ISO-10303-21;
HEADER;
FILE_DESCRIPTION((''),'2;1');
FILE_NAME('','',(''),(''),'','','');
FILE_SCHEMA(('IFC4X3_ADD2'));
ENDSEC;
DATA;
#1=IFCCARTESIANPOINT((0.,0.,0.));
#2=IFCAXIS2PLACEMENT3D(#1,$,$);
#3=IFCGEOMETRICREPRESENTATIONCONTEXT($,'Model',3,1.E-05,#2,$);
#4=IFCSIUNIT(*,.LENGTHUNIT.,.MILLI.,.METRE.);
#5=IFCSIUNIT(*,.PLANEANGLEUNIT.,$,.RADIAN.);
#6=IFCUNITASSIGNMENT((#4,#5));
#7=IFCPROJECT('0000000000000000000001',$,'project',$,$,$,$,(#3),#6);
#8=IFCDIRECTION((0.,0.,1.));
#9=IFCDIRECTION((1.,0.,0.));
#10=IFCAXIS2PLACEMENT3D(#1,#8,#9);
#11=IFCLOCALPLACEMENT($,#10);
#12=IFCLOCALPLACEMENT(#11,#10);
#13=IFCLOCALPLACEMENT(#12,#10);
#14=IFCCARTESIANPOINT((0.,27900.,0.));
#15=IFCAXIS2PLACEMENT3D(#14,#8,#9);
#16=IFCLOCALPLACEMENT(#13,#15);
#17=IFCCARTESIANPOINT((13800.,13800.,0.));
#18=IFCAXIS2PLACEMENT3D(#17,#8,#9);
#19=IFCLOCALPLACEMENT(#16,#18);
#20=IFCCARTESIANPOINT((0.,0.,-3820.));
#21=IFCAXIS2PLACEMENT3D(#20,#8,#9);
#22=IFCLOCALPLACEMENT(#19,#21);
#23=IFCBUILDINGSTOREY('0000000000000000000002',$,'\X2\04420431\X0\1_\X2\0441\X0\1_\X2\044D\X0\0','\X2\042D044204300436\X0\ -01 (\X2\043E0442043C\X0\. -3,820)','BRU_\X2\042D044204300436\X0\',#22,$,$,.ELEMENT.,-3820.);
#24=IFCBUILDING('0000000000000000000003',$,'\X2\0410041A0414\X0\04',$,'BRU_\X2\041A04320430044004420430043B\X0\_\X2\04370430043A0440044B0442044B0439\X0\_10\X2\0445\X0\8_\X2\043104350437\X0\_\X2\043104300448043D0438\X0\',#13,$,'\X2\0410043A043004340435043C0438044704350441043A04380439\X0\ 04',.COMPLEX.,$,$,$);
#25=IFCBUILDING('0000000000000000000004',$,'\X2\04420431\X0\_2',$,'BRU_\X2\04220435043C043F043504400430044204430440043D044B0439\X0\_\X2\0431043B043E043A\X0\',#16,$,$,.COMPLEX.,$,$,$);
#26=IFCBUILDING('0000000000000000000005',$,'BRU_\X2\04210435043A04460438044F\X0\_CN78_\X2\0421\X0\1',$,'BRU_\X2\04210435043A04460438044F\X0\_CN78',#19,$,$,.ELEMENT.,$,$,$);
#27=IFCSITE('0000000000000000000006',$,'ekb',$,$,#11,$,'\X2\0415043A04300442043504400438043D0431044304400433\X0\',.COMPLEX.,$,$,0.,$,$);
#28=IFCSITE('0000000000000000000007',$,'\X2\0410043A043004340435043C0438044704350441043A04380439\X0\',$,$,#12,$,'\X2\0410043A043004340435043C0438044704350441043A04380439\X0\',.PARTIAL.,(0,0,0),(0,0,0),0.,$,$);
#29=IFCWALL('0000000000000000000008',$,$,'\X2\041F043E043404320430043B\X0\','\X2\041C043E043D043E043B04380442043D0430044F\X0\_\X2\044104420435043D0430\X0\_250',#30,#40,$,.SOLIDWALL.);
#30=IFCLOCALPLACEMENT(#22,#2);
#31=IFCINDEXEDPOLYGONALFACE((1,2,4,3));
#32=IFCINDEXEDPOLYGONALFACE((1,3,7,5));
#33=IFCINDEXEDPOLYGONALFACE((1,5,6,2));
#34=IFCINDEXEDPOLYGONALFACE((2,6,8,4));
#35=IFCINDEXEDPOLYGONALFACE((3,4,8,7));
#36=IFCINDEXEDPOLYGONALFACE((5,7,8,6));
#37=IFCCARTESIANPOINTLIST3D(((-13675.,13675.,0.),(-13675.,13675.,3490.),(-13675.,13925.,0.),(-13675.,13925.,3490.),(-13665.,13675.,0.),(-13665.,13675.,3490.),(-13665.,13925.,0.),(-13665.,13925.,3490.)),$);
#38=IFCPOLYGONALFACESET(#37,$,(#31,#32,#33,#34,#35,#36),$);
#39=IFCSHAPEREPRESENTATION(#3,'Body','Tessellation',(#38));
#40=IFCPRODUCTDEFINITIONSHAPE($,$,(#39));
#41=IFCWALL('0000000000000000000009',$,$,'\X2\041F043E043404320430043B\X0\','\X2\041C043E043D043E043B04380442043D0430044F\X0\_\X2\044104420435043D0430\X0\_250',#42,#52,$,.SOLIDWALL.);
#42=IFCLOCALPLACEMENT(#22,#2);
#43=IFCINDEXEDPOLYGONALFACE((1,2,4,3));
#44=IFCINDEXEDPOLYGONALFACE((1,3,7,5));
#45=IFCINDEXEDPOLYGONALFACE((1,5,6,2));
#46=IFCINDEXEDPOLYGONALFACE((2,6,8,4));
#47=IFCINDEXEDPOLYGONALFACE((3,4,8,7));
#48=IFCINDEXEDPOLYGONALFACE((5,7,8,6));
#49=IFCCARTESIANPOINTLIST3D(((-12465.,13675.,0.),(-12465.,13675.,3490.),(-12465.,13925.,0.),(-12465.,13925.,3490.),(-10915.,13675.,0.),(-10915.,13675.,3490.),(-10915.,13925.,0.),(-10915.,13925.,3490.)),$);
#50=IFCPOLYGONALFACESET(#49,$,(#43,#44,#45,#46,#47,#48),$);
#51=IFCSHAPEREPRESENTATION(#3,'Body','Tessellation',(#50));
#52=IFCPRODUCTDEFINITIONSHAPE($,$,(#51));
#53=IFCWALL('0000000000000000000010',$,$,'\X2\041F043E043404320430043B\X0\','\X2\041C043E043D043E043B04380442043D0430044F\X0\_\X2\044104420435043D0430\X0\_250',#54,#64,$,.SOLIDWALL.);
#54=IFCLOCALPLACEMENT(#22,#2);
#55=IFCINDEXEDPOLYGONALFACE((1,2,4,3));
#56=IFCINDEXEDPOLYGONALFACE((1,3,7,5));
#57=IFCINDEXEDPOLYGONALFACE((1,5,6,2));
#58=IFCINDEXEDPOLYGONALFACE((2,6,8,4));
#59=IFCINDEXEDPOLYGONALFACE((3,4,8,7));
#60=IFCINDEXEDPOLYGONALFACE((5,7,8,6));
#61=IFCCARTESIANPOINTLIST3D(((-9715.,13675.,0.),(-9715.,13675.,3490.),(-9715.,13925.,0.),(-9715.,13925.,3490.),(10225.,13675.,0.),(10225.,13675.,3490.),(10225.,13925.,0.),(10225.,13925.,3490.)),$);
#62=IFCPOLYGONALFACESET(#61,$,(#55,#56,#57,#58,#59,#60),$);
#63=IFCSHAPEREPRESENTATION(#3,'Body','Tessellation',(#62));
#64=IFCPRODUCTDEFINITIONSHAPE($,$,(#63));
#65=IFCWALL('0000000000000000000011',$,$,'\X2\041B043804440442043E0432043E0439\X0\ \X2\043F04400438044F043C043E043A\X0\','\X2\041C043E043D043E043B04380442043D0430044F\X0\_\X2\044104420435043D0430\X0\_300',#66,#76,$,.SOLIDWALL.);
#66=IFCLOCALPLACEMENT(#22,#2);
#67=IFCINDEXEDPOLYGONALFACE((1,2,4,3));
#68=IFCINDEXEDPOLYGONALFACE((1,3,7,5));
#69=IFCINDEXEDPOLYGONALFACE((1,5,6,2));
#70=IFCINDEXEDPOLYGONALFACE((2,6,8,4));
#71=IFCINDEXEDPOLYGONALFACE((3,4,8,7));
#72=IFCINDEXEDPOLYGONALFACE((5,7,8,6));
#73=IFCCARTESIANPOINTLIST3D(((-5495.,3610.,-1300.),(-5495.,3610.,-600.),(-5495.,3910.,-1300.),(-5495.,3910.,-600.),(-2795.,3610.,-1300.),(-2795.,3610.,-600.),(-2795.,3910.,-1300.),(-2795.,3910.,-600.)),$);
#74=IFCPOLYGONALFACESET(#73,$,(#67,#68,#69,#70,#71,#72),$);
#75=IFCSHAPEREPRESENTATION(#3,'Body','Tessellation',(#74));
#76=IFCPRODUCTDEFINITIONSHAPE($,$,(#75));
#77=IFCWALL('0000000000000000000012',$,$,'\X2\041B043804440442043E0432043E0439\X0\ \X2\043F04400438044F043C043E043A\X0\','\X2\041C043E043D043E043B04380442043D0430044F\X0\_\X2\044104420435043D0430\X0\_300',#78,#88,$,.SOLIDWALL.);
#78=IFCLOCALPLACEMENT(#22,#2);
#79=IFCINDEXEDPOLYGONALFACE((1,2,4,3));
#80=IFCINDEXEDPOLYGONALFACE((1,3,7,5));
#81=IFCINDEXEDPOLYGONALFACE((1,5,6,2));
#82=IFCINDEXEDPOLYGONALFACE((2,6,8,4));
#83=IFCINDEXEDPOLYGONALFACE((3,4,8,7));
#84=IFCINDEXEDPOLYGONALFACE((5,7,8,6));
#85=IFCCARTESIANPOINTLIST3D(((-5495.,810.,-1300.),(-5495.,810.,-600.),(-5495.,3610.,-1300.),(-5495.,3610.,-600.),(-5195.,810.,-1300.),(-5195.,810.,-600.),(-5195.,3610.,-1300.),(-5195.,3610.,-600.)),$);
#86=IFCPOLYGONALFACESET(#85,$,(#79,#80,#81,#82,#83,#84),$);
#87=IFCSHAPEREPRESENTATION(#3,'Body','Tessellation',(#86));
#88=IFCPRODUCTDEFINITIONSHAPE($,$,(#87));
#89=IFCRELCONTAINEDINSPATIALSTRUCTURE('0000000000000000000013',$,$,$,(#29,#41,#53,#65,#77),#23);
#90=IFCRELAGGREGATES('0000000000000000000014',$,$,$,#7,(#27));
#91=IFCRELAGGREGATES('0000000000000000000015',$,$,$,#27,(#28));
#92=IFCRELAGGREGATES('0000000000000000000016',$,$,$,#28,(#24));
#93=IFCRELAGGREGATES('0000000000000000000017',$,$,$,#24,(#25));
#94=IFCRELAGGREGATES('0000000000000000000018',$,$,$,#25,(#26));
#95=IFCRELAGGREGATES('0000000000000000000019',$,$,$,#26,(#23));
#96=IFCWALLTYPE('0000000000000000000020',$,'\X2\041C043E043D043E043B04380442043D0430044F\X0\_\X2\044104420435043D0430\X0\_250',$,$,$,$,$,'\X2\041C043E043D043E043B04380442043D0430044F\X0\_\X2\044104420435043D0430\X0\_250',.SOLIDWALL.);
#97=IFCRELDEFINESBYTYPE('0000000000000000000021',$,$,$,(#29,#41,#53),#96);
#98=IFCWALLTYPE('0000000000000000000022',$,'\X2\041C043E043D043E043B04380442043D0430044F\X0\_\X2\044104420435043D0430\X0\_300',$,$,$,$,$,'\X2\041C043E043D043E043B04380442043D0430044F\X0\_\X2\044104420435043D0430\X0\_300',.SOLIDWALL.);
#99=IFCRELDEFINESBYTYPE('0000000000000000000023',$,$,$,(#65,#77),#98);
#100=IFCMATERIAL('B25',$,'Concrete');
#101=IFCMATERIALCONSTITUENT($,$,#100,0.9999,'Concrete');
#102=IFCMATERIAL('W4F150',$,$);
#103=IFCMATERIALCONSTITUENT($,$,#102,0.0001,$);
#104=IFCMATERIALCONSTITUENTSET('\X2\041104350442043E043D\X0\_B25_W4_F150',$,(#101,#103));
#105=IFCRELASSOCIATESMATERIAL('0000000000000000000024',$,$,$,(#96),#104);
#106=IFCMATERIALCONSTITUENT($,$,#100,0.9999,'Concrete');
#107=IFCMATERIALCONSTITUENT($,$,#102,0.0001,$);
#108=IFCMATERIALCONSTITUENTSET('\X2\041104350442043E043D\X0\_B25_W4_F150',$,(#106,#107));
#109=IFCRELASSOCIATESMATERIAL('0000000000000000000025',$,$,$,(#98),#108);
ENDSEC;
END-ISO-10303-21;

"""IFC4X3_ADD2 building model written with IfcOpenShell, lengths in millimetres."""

from ifc_helpers import new_model, si_unit, frame, origin, origin_with_axes, origin_2d_with_axis, place, context, project, spatial, rectangle, extrude, material, constituent, constituent_set, type_object, element, save


model = new_model("IFC4X3_ADD2")

# Units and contexts
model_context = context("Model", 3, precision=1e-05, world=origin())
ifc_project = project(units=[si_unit("LENGTHUNIT", "METRE", prefix="MILLI"), si_unit("PLANEANGLEUNIT", "RADIAN")], contexts=[model_context])

# Sites, buildings, storey
site_1_placement = place(None, origin_with_axes())
site_1 = spatial("IfcSite", under=ifc_project, at=site_1_placement, Name="ekb", LongName="Екатеринбург", CompositionType="COMPLEX", RefElevation=0.0)
site_2_placement = place(site_1_placement, origin_with_axes())
site_2 = spatial("IfcSite", under=site_1, at=site_2_placement, Name="Академический", LongName="Академический", CompositionType="PARTIAL", RefLatitude=(0, 0, 0), RefLongitude=(0, 0, 0), RefElevation=0.0)
building_1_placement = place(site_2_placement, origin_with_axes())
building_1 = spatial("IfcBuilding", under=site_2, at=building_1_placement, Name="АКД04", ObjectType="BRU_Квартал_закрытый_10х8_без_башни", LongName="Академический 04", CompositionType="COMPLEX")
building_2_placement = place(building_1_placement, frame((0.0, 27900.0, 0.0), z_axis=(0.0, 0.0, 1.0), x_axis=(1.0, 0.0, 0.0)))
building_2 = spatial("IfcBuilding", under=building_1, at=building_2_placement, Name="тб_2", ObjectType="BRU_Температурный_блок", CompositionType="COMPLEX")
building_3_placement = place(building_2_placement, frame((13800.0, 13800.0, 0.0), z_axis=(0.0, 0.0, 1.0), x_axis=(1.0, 0.0, 0.0)))
building_3 = spatial("IfcBuilding", under=building_2, at=building_3_placement, Name="BRU_Секция_CN78_С1", ObjectType="BRU_Секция_CN78", CompositionType="ELEMENT")
storey_placement = place(building_3_placement, frame((0.0, 0.0, -3820.0), z_axis=(0.0, 0.0, 1.0), x_axis=(1.0, 0.0, 0.0)))
storey = spatial("IfcBuildingStorey", under=building_3, at=storey_placement, Name="тб1_с1_э0", Description="Этаж -01 (отм. -3,820)", ObjectType="BRU_Этаж", CompositionType="ELEMENT", Elevation=-3820.0)

# Shared definitions
ifc_material_1 = material(Name="B25", Category="Concrete")
ifc_material_2 = material(Name="W4F150")

# Walls
ifc_constituent_1 = constituent(ifc_material_1, Category="Concrete", fraction=0.9999)
ifc_constituent_2 = constituent(ifc_material_2, fraction=0.0001)
ifc_constituent_set_1 = constituent_set(constituents=[ifc_constituent_1, ifc_constituent_2], Name="Бетон_B25_W4_F150")
wall_type_1 = type_object("IfcWallType", Name="Монолитная_стена_250", ElementType="Монолитная_стена_250", PredefinedType="SOLIDWALL", material=ifc_constituent_set_1)
wall_1_placement = place(storey_placement, frame((-13675.0, 13800.0, 0.0), z_axis=(0.0, 0.0, 1.0), x_axis=(1.0, 0.0, 0.0)))
element("IfcWall", 1, at=wall_1_placement, inside=storey, type_object=wall_type_1, Description="Подвал", ObjectType="Монолитная_стена_250", PredefinedType="SOLIDWALL", context=model_context, shape_type="SweptSolid", body=[
    extrude(rectangle(XDim=10.0, YDim=250.0, at=origin_2d_with_axis()), frame((5.0, 0.0, 0.0), z_axis=(0.0, 0.0, 1.0), x_axis=(1.0, 0.0, 0.0)), (0.0, 0.0, 1.0), 3490.0),
])
wall_2_placement = place(storey_placement, frame((-12465.0, 13800.0, 0.0), z_axis=(0.0, 0.0, 1.0), x_axis=(1.0, 0.0, 0.0)))
element("IfcWall", 2, at=wall_2_placement, inside=storey, type_object=wall_type_1, Description="Подвал", ObjectType="Монолитная_стена_250", PredefinedType="SOLIDWALL", context=model_context, shape_type="SweptSolid", body=[
    extrude(rectangle(XDim=1550.0, YDim=250.0, at=origin_2d_with_axis()), frame((775.0, 0.0, 0.0), z_axis=(0.0, 0.0, 1.0), x_axis=(1.0, 0.0, 0.0)), (0.0, 0.0, 1.0), 3490.0),
])
wall_3_placement = place(storey_placement, frame((-9715.0, 13800.0, 0.0), z_axis=(0.0, 0.0, 1.0), x_axis=(1.0, 0.0, 0.0)))
element("IfcWall", 3, at=wall_3_placement, inside=storey, type_object=wall_type_1, Description="Подвал", ObjectType="Монолитная_стена_250", PredefinedType="SOLIDWALL", context=model_context, shape_type="SweptSolid", body=[
    extrude(rectangle(XDim=19940.0, YDim=250.0, at=origin_2d_with_axis()), frame((9970.0, 0.0, 0.0), z_axis=(0.0, 0.0, 1.0), x_axis=(1.0, 0.0, 0.0)), (0.0, 0.0, 1.0), 3490.0),
])
ifc_constituent_3 = constituent(ifc_material_1, Category="Concrete", fraction=0.9999)
ifc_constituent_4 = constituent(ifc_material_2, fraction=0.0001)
ifc_constituent_set_2 = constituent_set(constituents=[ifc_constituent_3, ifc_constituent_4], Name="Бетон_B25_W4_F150")
wall_type_2 = type_object("IfcWallType", Name="Монолитная_стена_300", ElementType="Монолитная_стена_300", PredefinedType="SOLIDWALL", material=ifc_constituent_set_2)
wall_4_placement = place(storey_placement, frame((-2795.0, 3760.0, -1300.0), z_axis=(0.0, 0.0, 1.0), x_axis=(-1.0, 0.0, 0.0)))
element("IfcWall", 4, at=wall_4_placement, inside=storey, type_object=wall_type_2, Description="Лифтовой приямок", ObjectType="Монолитная_стена_300", PredefinedType="SOLIDWALL", context=model_context, shape_type="SweptSolid", body=[
    extrude(rectangle(XDim=2700.0, YDim=300.0, at=origin_2d_with_axis()), frame((1350.0, 0.0, 0.0), z_axis=(0.0, 0.0, 1.0), x_axis=(1.0, 0.0, 0.0)), (0.0, 0.0, 1.0), 700.0),
])
wall_5_placement = place(storey_placement, frame((-5345.0, 3610.0, -1300.0), z_axis=(0.0, 0.0, 1.0), x_axis=(0.0, -1.0, 0.0)))
element("IfcWall", 5, at=wall_5_placement, inside=storey, type_object=wall_type_2, Description="Лифтовой приямок", ObjectType="Монолитная_стена_300", PredefinedType="SOLIDWALL", context=model_context, shape_type="SweptSolid", body=[
    extrude(rectangle(XDim=2800.0, YDim=300.0, at=origin_2d_with_axis()), frame((1400.0, 0.0, 0.0), z_axis=(0.0, 0.0, 1.0), x_axis=(1.0, 0.0, 0.0)), (0.0, 0.0, 1.0), 700.0),
])

save(model, "model.ifc")
